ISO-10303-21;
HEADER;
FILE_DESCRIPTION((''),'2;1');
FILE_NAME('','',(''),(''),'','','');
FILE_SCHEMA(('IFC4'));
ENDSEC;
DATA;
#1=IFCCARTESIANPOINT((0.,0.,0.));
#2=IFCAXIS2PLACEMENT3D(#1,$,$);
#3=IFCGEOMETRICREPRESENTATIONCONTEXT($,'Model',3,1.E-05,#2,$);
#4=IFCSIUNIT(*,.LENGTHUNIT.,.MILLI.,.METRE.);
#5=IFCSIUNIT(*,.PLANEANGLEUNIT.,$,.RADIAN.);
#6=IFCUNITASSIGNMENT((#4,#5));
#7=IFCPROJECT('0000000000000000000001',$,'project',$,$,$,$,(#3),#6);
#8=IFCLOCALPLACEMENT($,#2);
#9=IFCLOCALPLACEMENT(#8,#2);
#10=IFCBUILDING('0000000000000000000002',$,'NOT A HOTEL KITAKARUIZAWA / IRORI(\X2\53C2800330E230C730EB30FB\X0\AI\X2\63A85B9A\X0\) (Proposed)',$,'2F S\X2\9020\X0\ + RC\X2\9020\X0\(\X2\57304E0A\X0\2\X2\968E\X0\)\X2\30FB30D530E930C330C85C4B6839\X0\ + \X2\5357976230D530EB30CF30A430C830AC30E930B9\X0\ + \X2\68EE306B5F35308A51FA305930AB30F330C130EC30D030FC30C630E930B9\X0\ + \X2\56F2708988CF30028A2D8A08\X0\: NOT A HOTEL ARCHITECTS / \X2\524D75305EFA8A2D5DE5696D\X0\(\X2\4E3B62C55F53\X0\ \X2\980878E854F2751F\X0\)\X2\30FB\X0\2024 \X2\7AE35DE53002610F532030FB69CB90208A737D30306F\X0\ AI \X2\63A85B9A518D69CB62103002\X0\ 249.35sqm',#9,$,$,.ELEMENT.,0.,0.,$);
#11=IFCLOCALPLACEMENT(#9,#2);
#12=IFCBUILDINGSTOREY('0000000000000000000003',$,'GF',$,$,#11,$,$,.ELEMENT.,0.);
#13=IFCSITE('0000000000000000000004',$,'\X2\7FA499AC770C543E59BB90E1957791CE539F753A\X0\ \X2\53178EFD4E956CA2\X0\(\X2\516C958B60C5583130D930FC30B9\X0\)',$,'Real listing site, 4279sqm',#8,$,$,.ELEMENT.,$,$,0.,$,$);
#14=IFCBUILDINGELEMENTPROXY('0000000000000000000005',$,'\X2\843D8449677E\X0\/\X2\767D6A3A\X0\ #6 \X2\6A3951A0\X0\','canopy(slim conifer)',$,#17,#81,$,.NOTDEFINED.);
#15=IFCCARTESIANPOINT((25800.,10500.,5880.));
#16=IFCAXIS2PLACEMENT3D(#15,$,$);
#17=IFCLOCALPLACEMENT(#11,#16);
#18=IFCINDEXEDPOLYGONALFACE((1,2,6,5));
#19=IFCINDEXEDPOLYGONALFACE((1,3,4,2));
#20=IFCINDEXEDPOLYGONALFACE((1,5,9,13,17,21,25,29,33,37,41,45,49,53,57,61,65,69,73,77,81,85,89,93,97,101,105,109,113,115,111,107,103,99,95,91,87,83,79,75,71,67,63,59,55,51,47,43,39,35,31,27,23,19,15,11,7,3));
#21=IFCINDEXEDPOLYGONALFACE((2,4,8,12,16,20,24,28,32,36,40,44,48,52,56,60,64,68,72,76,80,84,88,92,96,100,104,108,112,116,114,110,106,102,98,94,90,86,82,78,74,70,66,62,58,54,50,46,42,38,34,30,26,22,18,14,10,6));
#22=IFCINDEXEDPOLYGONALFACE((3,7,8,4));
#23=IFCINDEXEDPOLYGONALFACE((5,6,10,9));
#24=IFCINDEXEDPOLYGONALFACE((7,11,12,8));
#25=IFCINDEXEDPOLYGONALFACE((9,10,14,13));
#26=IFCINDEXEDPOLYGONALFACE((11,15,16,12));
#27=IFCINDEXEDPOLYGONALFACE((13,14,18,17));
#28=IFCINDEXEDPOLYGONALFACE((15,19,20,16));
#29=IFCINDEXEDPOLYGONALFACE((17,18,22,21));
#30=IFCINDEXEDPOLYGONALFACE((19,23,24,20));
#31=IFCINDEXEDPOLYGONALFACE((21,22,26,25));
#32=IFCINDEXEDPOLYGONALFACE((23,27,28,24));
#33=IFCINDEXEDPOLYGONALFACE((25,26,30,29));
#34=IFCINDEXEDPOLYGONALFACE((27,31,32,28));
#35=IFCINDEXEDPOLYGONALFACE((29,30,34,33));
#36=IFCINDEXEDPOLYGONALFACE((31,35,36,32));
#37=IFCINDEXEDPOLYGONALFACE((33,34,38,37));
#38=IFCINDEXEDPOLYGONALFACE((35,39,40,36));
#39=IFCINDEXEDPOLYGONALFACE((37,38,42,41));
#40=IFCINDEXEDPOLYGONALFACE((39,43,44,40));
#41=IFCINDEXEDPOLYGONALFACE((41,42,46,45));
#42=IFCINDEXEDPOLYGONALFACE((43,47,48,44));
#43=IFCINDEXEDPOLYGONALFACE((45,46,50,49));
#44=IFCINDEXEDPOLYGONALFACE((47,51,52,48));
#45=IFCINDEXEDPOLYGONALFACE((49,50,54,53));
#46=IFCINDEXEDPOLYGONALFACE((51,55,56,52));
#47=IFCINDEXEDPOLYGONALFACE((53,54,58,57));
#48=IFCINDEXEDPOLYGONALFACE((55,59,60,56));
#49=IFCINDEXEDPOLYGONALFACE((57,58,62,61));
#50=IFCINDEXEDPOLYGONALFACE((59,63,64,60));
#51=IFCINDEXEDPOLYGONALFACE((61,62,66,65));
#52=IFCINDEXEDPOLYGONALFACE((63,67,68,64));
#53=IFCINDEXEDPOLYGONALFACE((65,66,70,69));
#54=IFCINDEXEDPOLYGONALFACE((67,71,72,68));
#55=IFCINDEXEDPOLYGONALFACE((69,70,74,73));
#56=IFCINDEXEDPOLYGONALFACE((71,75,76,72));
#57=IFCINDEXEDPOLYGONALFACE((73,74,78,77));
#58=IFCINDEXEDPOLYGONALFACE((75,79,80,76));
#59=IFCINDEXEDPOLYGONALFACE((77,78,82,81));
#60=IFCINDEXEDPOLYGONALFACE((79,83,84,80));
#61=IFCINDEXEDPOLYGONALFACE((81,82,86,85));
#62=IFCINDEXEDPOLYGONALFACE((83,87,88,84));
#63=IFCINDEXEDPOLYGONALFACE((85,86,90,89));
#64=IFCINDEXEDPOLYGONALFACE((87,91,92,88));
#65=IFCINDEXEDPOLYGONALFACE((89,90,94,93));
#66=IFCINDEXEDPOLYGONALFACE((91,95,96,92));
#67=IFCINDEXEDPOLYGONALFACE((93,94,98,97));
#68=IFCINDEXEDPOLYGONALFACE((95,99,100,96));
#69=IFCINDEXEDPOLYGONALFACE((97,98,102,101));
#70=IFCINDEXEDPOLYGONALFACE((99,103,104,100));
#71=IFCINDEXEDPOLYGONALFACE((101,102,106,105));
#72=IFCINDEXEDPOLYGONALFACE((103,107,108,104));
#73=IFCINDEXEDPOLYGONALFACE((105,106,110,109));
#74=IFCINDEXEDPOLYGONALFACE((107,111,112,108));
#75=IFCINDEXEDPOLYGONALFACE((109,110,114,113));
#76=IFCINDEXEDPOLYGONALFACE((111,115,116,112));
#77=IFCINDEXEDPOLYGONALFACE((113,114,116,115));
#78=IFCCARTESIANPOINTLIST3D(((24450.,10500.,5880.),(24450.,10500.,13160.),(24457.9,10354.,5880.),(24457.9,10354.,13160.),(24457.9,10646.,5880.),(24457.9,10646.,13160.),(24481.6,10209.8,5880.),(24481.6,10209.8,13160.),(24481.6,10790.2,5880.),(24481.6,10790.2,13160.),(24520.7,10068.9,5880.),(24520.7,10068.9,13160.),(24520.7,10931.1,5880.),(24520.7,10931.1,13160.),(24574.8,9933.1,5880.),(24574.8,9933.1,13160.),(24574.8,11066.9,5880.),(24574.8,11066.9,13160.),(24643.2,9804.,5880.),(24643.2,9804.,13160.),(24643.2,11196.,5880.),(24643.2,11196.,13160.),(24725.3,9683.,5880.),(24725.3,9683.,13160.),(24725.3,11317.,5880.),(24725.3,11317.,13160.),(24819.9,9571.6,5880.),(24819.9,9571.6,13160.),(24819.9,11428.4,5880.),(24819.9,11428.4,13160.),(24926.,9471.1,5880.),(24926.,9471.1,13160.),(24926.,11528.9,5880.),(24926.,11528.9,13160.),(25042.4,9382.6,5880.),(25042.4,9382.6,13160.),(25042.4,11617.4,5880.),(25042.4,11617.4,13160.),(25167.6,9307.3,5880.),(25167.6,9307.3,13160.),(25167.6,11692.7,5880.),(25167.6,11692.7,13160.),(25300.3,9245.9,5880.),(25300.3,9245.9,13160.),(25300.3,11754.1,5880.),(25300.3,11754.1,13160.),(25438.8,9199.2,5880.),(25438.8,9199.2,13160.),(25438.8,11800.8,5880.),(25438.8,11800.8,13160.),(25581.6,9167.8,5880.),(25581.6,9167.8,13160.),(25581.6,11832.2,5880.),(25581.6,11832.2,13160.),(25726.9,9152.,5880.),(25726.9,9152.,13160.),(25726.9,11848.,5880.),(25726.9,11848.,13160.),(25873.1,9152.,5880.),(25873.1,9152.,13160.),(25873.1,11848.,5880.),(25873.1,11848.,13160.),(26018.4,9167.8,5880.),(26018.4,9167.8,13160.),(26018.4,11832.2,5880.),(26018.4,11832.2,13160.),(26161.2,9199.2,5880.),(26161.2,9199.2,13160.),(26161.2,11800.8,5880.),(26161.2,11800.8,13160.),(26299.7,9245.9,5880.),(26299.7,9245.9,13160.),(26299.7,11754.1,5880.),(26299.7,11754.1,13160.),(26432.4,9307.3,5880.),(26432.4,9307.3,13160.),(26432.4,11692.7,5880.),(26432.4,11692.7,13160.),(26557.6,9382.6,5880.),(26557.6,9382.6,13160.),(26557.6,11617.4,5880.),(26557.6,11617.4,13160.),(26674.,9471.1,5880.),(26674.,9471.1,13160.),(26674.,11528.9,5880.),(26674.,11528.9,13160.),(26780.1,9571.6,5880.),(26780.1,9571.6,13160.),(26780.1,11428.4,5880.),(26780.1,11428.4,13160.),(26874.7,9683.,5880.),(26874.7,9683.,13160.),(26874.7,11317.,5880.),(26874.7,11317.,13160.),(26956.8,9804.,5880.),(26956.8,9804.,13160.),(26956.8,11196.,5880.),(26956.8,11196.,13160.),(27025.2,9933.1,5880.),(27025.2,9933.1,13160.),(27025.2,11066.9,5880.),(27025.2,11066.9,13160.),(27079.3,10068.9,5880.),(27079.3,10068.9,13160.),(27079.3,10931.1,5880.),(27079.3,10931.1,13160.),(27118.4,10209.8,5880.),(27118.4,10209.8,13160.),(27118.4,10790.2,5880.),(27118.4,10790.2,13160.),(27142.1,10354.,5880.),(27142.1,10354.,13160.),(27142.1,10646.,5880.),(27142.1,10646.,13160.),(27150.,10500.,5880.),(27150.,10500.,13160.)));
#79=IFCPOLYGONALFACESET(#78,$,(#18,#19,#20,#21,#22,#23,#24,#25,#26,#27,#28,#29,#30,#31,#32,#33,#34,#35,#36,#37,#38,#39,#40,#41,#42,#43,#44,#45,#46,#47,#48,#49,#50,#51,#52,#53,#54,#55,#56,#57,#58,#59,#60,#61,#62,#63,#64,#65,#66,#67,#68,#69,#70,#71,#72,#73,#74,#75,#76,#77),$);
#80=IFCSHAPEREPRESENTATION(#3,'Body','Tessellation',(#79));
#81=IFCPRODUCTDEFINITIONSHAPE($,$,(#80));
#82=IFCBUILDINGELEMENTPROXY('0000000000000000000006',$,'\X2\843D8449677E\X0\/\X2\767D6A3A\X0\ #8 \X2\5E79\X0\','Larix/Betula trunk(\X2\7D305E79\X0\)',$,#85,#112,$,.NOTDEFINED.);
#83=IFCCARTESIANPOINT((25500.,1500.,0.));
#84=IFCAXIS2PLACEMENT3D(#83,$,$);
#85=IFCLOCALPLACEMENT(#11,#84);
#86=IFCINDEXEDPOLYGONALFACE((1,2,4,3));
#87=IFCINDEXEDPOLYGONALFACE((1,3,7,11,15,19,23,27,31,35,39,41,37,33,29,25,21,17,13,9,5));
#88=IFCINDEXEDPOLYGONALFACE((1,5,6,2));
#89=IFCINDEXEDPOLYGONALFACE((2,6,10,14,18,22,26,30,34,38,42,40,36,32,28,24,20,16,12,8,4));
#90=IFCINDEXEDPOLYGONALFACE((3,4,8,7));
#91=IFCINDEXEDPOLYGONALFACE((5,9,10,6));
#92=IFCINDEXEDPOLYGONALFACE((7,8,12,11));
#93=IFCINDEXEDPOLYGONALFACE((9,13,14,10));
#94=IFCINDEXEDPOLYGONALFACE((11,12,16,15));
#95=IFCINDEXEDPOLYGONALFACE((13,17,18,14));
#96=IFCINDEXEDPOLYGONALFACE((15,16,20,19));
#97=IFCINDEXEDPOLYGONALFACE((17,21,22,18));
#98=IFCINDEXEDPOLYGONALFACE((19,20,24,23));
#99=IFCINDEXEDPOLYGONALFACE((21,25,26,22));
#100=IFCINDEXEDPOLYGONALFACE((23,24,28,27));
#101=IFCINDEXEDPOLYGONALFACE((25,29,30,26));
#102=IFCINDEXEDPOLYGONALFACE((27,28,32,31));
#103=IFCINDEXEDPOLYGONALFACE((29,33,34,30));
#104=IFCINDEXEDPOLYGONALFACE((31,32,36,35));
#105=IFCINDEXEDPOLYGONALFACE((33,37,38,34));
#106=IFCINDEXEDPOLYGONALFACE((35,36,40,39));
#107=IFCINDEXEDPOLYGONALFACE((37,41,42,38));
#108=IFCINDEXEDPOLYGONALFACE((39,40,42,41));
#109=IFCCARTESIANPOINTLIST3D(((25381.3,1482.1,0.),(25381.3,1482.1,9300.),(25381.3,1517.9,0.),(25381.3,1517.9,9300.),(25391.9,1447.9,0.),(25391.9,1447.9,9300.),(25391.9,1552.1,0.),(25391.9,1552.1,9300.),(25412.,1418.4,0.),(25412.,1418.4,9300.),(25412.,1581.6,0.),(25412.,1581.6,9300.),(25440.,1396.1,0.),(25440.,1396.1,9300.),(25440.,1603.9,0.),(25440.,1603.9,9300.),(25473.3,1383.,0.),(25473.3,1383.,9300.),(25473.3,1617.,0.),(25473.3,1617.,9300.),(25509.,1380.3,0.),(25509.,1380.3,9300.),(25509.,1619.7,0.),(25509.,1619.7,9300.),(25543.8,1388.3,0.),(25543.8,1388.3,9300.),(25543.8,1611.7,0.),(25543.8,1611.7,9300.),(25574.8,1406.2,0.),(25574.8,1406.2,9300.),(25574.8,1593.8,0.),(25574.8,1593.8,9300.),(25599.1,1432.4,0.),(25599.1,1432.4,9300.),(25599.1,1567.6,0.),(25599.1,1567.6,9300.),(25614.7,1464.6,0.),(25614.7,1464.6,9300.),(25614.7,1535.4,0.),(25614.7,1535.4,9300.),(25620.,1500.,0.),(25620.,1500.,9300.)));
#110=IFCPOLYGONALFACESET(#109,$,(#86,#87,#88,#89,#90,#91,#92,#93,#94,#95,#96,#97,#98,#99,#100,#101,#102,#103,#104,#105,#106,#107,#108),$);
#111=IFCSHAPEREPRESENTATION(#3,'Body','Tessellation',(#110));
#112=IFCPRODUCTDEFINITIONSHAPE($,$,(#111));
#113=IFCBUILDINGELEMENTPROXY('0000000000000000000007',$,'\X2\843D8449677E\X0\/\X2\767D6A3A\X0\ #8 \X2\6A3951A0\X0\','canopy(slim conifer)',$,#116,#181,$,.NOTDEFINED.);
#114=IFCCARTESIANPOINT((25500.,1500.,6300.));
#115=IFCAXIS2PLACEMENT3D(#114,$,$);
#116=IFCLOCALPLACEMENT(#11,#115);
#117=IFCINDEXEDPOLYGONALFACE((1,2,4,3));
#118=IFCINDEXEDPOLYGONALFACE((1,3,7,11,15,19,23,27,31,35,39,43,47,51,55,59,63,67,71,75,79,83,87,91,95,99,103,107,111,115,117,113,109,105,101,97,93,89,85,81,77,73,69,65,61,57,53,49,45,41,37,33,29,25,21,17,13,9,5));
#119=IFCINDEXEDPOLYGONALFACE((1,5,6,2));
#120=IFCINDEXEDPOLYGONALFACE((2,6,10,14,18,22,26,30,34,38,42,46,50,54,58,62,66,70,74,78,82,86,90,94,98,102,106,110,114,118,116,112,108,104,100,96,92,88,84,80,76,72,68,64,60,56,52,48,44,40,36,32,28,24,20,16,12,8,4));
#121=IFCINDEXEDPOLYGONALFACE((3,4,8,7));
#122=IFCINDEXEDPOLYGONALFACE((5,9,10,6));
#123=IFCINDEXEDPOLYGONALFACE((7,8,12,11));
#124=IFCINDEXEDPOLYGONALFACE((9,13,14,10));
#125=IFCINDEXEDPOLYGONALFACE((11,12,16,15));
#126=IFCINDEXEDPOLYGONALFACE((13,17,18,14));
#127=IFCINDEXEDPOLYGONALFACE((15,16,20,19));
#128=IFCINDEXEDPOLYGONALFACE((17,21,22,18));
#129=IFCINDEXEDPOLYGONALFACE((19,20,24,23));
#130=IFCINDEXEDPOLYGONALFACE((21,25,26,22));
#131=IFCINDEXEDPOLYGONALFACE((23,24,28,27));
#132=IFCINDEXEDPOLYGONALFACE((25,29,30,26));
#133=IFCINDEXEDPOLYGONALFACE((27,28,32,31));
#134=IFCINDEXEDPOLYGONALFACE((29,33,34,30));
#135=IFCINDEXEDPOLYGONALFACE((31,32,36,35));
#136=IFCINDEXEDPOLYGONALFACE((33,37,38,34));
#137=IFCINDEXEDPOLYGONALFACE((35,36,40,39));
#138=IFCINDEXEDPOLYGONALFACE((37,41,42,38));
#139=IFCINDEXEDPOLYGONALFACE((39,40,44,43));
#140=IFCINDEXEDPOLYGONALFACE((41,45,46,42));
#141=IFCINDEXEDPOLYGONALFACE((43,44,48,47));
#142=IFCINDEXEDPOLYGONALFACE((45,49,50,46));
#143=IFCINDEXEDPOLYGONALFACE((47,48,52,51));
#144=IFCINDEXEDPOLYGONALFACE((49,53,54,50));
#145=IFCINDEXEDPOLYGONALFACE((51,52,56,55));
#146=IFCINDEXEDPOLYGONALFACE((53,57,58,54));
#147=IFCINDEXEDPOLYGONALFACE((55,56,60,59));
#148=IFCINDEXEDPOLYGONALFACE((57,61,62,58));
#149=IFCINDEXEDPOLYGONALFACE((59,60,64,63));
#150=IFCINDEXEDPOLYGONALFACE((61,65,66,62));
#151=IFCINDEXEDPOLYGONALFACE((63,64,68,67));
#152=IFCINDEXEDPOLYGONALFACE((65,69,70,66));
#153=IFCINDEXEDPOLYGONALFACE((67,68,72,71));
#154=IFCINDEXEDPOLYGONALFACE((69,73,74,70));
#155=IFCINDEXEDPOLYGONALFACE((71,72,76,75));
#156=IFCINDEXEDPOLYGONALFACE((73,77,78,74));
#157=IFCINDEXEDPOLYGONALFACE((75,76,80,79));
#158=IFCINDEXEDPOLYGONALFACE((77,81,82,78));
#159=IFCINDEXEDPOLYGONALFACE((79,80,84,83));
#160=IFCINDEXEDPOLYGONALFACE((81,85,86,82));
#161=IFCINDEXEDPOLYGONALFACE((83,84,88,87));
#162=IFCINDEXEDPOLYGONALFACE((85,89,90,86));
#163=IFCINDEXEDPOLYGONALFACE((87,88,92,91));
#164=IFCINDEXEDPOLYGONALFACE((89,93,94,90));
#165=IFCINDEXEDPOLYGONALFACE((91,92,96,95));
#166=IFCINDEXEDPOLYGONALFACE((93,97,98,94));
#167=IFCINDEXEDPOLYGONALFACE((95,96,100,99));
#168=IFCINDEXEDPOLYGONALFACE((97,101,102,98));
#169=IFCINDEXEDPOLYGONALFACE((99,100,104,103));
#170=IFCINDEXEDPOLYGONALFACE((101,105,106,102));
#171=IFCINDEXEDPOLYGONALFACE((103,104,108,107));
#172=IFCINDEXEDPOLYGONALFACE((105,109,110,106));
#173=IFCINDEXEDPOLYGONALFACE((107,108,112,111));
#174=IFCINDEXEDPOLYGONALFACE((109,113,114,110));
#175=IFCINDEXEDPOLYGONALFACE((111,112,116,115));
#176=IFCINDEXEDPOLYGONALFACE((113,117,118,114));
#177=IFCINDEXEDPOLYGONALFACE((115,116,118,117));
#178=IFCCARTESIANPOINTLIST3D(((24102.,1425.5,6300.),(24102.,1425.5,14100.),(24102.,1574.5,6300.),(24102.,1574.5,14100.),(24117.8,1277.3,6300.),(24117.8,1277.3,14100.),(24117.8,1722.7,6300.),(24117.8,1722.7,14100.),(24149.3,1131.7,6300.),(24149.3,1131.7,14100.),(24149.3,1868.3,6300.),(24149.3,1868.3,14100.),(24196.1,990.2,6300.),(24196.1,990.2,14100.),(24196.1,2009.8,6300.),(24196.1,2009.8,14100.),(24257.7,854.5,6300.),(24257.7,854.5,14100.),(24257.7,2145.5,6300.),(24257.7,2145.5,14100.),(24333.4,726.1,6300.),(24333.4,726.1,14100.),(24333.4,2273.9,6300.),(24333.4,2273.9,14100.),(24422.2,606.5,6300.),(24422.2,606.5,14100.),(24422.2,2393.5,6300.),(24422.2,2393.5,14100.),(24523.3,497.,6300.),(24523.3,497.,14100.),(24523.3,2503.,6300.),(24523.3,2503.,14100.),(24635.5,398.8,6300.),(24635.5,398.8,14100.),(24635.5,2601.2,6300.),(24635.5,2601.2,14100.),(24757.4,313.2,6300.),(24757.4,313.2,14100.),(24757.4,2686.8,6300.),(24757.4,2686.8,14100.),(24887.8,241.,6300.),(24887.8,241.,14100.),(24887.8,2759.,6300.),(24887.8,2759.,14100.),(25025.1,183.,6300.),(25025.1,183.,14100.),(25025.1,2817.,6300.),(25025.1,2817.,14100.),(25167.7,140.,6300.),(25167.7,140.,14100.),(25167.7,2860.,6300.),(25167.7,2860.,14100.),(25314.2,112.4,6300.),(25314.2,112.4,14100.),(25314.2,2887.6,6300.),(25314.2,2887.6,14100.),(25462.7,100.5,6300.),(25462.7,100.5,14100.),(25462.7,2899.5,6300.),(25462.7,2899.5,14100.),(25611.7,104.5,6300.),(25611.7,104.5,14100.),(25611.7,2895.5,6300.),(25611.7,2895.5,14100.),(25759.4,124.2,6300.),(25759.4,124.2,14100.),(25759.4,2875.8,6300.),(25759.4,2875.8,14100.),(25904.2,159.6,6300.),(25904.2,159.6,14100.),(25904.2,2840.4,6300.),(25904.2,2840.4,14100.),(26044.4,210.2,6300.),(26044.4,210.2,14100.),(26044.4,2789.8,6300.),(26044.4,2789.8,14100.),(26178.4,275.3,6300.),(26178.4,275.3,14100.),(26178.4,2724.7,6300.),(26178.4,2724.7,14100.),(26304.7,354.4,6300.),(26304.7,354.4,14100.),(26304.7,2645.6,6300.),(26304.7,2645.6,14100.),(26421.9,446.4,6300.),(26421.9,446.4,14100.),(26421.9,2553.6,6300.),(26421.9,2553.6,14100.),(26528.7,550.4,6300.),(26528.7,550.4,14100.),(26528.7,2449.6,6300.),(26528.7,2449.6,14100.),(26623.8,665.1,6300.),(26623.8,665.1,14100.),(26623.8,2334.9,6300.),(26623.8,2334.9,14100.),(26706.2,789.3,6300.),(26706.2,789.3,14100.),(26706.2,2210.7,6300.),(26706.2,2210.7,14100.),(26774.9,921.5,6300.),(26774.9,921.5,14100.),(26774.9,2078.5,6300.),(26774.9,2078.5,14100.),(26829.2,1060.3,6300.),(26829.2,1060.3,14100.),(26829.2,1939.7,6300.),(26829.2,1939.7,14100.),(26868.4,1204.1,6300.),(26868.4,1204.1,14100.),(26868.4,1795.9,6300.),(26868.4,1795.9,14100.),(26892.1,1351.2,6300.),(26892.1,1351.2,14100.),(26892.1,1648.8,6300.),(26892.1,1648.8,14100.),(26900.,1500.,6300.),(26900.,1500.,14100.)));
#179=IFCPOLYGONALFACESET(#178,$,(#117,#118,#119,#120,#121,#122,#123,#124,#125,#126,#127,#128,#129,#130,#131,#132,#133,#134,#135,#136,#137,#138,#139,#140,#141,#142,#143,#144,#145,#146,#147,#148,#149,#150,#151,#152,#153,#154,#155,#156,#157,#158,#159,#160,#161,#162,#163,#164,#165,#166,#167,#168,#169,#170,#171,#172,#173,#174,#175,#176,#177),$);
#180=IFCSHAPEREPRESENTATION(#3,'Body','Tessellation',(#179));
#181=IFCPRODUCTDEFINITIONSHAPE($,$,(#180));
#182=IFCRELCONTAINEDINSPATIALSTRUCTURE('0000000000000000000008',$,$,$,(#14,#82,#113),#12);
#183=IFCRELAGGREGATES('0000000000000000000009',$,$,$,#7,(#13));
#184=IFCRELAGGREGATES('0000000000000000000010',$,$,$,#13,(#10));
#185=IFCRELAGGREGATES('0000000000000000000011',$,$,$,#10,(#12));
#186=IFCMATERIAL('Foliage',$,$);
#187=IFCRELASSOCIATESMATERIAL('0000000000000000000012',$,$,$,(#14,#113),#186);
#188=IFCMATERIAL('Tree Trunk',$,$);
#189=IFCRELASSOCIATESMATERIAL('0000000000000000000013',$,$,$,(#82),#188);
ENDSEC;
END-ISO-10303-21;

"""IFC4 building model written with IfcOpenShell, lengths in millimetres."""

from ifc_helpers import new_model, si_unit, frame, origin, origin_2d, place, context, project, spatial, circle, extrude, material, element, save


model = new_model("IFC4")

# Units and contexts
model_context = context("Model", 3, precision=1e-05, world=origin())
ifc_project = project(units=[si_unit("LENGTHUNIT", "METRE", prefix="MILLI"), si_unit("PLANEANGLEUNIT", "RADIAN")], contexts=[model_context])

# Site, building, storey
site_placement = place(None, origin())
site = spatial("IfcSite", under=ifc_project, at=site_placement, Name="群馬県吾妻郡長野原町 北軽井沢(公開情報ベース)", ObjectType="Real listing site, 4279sqm", CompositionType="ELEMENT", RefElevation=0.0)
building_placement = place(site_placement, origin())
building = spatial("IfcBuilding", under=site, at=building_placement, Name="NOT A HOTEL KITAKARUIZAWA / IRORI(参考モデル・AI推定) (Proposed)", ObjectType="2F S造 + RC造(地上2階)・フラット屋根 + 南面フルハイトガラス + 森に張り出すカンチレバーテラス + 囲炉裏。設計: NOT A HOTEL ARCHITECTS / 前田建設工業(主担当 須磨哲生)・2024 竣工。意匠・構造詳細は AI 推定再構成。 249.35sqm", CompositionType="ELEMENT", ElevationOfRefHeight=0.0, ElevationOfTerrain=0.0)
storey_placement = place(building_placement, origin())
storey = spatial("IfcBuildingStorey", under=building, at=storey_placement, Name="GF", CompositionType="ELEMENT", Elevation=0.0)

# Building element proxies
ifc_material_1 = material(Name="Tree Trunk")
ifc_material_2 = material(Name="Foliage")
proxy_1_placement = place(storey_placement, frame((25800.0, 10500.0, 5880.0)))
element("IfcBuildingElementProxy", 1, at=proxy_1_placement, inside=storey, material=ifc_material_2, Name="落葉松/白樺 #6 樹冠", Description="canopy(slim conifer)", PredefinedType="NOTDEFINED", context=model_context, shape_type="SweptSolid", body=[
    extrude(circle(Radius=1350.0, at=origin_2d()), frame((25800.0, 10500.0, 5880.0)), (0.0, 0.0, 1.0), 7280.0),
])
proxy_2_placement = place(storey_placement, frame((25500.0, 1500.0, 0.0)))
element("IfcBuildingElementProxy", 2, at=proxy_2_placement, inside=storey, material=ifc_material_1, Name="落葉松/白樺 #8 幹", Description="Larix/Betula trunk(細幹)", PredefinedType="NOTDEFINED", context=model_context, shape_type="SweptSolid", body=[
    extrude(circle(Radius=120.0, at=origin_2d()), frame((25500.0, 1500.0, 0.0)), (0.0, 0.0, 1.0), 9300.0),
])
proxy_3_placement = place(storey_placement, frame((25500.0, 1500.0, 6300.0)))
element("IfcBuildingElementProxy", 3, at=proxy_3_placement, inside=storey, material=ifc_material_2, Name="落葉松/白樺 #8 樹冠", Description="canopy(slim conifer)", PredefinedType="NOTDEFINED", context=model_context, shape_type="SweptSolid", body=[
    extrude(circle(Radius=1400.0, at=origin_2d()), frame((25500.0, 1500.0, 6300.0)), (0.0, 0.0, 1.0), 7800.0),
])

save(model, "model.ifc")
